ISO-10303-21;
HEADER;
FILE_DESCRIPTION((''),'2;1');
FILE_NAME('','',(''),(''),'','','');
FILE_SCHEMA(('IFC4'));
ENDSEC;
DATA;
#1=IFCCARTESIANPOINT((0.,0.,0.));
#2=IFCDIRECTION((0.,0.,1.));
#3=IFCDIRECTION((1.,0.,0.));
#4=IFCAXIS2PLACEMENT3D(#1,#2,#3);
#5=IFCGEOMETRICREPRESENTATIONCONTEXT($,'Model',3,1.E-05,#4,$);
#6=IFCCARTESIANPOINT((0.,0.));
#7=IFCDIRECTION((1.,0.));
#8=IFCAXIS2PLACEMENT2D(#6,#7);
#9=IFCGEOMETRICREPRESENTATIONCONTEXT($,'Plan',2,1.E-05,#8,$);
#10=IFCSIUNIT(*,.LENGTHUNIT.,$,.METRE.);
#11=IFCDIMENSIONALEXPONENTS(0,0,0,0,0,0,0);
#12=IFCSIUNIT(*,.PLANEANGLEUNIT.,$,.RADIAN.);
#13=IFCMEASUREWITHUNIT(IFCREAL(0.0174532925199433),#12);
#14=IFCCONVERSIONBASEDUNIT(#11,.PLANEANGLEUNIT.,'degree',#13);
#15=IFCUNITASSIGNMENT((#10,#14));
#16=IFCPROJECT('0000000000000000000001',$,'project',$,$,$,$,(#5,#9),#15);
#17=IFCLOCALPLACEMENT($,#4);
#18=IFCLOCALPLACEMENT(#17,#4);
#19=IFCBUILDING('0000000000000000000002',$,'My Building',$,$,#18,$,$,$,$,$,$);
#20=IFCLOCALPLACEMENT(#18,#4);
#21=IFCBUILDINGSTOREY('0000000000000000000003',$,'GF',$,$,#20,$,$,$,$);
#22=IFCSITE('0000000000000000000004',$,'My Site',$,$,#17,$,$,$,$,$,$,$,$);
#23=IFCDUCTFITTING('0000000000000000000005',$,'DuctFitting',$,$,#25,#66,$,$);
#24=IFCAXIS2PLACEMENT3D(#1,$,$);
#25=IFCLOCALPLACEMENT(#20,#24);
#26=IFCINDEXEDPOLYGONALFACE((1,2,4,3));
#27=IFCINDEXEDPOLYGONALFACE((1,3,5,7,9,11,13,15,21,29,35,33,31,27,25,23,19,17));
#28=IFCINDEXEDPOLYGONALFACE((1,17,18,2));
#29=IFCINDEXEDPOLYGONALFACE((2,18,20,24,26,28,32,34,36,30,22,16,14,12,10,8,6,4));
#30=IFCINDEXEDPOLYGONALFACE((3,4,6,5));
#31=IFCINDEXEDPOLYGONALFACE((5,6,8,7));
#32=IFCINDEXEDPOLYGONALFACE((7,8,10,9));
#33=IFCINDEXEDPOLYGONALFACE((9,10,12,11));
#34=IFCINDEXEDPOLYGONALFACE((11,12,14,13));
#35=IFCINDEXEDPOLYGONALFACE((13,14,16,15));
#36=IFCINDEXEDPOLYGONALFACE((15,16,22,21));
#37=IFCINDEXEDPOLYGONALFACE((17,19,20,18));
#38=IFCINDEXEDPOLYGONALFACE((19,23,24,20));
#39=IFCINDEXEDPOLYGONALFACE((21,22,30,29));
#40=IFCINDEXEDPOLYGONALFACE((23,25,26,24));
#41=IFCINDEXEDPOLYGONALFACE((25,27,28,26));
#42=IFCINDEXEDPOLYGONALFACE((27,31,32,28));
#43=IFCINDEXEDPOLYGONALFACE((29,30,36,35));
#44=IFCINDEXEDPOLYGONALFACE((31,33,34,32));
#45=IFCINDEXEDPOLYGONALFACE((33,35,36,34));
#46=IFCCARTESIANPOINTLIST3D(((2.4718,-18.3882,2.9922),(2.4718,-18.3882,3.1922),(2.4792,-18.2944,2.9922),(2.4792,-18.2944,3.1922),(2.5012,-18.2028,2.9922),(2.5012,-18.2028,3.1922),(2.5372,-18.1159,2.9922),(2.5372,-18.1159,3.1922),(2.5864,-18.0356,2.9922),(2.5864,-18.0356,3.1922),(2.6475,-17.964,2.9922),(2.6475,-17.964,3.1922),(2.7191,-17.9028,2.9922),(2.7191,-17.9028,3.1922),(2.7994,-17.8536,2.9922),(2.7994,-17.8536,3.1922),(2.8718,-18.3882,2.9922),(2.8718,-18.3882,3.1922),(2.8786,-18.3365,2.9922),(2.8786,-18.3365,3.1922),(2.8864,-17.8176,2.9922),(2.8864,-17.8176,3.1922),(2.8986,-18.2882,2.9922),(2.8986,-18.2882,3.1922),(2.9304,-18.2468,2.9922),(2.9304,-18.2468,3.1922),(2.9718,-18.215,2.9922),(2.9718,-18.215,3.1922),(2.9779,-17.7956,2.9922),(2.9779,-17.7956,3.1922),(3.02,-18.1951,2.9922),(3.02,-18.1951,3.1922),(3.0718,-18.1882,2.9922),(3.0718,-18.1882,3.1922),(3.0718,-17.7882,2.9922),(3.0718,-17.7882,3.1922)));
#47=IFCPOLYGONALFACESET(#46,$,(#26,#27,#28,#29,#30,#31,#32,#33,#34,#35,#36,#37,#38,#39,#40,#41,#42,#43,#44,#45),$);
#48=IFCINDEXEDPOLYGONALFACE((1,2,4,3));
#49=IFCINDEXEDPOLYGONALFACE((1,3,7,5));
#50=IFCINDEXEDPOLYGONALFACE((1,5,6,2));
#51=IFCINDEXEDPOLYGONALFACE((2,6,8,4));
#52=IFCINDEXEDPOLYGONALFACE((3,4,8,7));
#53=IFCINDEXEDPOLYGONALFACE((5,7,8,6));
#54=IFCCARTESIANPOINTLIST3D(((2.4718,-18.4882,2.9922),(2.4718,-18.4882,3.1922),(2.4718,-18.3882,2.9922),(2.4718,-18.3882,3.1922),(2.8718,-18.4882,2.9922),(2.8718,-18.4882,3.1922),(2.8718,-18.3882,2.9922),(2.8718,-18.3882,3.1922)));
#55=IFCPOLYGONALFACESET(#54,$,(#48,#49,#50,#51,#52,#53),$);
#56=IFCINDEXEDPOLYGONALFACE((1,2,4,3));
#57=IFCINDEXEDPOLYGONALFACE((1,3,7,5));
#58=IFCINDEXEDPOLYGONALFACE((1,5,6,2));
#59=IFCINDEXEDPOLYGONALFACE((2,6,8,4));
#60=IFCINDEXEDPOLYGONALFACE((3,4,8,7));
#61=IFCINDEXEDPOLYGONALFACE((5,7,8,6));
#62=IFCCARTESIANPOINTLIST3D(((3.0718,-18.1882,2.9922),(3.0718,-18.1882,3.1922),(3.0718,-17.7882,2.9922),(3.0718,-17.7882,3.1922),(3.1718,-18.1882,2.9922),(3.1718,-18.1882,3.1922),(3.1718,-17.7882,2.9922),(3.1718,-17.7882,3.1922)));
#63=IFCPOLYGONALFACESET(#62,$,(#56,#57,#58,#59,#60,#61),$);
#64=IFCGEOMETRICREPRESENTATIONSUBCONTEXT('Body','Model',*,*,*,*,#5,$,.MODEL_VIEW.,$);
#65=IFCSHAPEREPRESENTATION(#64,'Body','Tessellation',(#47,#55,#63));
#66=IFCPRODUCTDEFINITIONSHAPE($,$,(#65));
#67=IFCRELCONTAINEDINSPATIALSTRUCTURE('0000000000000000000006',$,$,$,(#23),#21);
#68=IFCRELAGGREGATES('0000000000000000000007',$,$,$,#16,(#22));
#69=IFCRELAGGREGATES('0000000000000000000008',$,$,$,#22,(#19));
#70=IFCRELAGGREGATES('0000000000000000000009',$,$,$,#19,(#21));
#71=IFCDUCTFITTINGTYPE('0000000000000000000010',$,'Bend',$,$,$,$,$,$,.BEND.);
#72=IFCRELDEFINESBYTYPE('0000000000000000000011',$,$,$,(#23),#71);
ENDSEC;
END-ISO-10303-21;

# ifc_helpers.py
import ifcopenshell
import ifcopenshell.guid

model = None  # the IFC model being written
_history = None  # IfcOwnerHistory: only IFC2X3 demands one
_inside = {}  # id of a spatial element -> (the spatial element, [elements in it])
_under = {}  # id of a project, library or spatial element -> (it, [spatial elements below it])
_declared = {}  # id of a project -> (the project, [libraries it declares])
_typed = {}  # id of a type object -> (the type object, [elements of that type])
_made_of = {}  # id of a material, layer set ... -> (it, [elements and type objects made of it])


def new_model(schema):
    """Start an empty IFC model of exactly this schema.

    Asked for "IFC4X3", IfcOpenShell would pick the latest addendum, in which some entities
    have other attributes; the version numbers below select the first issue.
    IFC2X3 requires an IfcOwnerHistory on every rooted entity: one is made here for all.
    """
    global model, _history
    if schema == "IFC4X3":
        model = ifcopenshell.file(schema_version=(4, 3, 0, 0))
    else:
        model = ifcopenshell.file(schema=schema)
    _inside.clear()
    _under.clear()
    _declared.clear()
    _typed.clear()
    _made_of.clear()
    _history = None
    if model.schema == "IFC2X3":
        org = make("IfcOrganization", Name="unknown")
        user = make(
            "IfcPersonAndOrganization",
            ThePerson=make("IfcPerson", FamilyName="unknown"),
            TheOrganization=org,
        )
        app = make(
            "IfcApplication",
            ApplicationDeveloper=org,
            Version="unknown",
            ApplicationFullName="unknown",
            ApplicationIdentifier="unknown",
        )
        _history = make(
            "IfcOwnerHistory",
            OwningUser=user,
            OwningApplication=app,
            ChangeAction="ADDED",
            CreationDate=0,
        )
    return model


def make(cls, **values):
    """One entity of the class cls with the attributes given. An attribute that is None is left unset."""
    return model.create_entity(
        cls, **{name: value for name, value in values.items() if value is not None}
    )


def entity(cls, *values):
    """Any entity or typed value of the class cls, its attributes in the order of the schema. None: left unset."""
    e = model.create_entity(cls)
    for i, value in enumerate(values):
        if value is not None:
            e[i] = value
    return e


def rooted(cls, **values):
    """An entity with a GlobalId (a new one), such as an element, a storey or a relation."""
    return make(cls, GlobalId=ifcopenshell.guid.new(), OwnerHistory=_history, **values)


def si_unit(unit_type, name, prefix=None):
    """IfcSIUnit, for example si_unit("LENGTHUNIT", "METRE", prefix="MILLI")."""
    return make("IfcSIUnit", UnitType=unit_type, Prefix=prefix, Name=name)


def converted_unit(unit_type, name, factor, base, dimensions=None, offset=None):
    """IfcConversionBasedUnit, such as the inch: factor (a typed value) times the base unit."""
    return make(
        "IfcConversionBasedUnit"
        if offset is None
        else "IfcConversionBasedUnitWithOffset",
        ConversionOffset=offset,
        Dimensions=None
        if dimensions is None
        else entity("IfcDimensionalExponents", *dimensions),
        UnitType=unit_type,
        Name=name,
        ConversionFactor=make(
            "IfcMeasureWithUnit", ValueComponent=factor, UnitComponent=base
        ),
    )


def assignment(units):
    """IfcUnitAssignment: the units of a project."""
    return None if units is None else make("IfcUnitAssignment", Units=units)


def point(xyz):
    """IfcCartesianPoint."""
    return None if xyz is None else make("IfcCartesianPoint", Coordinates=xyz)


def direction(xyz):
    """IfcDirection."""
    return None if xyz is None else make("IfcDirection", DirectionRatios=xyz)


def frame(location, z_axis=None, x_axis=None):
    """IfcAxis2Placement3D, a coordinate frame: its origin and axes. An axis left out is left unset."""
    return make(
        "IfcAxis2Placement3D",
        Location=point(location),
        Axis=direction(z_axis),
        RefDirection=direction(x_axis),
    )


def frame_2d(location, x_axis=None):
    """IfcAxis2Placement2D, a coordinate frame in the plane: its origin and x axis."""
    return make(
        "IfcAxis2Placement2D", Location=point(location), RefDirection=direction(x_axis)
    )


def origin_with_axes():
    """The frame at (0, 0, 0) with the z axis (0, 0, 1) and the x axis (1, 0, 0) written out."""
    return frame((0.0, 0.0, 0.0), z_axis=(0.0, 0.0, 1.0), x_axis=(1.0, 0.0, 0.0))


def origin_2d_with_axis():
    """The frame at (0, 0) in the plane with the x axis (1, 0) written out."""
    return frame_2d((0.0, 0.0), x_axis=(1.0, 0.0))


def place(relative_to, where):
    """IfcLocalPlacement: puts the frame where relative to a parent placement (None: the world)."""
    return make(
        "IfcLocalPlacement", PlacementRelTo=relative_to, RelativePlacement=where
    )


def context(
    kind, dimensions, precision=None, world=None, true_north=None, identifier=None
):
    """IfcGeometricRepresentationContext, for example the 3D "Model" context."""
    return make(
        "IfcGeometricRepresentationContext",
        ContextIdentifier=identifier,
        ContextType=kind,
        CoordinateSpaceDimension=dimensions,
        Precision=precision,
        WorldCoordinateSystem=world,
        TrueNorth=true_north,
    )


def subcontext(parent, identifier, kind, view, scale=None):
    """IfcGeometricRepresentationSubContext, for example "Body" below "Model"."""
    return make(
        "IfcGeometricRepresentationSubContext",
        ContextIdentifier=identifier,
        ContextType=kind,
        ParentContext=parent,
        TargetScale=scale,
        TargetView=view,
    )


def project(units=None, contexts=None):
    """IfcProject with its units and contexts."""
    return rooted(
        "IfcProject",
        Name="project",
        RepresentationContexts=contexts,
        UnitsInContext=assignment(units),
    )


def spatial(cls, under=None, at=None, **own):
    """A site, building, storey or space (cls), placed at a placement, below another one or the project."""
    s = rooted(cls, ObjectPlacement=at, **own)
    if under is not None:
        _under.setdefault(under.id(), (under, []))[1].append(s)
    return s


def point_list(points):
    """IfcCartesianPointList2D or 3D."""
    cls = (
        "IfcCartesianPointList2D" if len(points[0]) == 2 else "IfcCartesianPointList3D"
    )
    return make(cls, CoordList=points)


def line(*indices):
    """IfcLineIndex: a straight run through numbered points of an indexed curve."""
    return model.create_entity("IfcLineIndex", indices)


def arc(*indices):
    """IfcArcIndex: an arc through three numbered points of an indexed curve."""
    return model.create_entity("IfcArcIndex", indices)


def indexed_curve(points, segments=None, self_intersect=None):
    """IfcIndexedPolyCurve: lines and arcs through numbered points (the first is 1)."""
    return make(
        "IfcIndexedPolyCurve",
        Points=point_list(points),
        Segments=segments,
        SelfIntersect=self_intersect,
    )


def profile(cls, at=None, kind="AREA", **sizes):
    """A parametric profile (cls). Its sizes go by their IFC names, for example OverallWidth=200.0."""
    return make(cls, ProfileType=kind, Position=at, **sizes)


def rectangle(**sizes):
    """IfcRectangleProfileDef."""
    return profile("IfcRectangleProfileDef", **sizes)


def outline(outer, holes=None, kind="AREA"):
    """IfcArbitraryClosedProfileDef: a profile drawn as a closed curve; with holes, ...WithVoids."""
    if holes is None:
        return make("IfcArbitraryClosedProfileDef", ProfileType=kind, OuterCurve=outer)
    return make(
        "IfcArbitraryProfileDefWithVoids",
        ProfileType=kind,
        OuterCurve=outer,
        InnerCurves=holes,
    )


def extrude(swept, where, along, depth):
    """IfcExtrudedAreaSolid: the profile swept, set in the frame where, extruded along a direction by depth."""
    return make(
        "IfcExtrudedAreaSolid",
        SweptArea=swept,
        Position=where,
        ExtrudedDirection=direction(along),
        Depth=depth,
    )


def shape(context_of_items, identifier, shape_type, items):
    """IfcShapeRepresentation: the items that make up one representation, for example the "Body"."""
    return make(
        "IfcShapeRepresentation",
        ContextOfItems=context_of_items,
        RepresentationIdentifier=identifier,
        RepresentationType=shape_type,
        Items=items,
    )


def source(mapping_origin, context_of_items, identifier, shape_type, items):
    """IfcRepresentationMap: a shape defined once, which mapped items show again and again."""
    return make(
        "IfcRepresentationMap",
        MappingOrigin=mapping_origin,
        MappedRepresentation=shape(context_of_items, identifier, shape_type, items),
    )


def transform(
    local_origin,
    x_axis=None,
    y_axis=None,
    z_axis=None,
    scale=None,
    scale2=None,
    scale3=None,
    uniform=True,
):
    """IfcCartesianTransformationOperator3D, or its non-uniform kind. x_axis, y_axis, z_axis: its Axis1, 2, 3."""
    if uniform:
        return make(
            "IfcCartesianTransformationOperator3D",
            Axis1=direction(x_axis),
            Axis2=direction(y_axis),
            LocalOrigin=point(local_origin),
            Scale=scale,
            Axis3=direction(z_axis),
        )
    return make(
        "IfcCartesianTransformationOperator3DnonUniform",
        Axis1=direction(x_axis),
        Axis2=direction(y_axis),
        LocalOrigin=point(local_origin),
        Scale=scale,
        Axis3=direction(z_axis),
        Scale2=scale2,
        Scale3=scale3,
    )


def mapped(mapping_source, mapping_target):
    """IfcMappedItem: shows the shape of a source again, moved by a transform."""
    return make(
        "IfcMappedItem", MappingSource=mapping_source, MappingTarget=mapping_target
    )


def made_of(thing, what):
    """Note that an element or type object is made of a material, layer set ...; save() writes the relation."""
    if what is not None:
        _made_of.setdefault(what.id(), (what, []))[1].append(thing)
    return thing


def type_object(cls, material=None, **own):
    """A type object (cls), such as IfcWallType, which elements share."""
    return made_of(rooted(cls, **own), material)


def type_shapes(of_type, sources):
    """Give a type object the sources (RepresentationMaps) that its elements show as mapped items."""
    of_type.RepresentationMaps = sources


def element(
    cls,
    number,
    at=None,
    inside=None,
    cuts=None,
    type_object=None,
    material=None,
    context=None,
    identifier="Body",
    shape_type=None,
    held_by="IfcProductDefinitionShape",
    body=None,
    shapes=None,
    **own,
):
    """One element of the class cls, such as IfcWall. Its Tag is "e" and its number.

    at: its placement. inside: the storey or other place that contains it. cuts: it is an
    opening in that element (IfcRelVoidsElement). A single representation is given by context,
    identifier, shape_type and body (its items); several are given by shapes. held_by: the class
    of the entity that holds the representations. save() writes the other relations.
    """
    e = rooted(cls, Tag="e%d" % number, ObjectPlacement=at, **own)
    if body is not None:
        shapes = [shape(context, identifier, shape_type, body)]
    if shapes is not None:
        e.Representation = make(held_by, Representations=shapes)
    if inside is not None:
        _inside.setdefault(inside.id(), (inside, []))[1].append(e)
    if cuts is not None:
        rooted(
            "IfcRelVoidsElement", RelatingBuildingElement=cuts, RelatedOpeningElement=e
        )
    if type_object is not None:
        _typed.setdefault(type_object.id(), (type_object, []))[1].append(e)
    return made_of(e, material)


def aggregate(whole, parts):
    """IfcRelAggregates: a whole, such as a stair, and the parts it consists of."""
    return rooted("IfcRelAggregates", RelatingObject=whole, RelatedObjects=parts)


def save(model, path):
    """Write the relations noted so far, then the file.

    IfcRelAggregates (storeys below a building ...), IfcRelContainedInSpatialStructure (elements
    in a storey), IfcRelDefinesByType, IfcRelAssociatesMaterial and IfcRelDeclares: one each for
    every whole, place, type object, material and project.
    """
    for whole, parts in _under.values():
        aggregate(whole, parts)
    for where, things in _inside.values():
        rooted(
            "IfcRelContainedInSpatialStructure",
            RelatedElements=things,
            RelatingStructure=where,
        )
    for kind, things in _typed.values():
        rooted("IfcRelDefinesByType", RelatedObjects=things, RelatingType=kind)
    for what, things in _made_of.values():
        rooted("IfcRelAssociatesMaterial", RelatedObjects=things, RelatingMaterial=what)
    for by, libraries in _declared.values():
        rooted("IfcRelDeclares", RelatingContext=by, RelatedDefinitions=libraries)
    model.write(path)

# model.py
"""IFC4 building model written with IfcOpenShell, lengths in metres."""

from ifc_helpers import new_model, entity, si_unit, converted_unit, frame, origin_with_axes, origin_2d_with_axis, place, context, subcontext, project, spatial, line, arc, indexed_curve, rectangle, outline, extrude, source, transform, mapped, type_object, type_shapes, element, save


model = new_model("IFC4")

# Units and contexts
model_context = context("Model", 3, precision=1e-05, world=origin_with_axes())
plan_context = context("Plan", 2, precision=1e-05, world=origin_2d_with_axis())
body_context_1 = subcontext(model_context, "Body", "Model", "MODEL_VIEW")
ifc_project = project(units=[si_unit("LENGTHUNIT", "METRE"), converted_unit("PLANEANGLEUNIT", "degree", entity("IfcReal", 0.0174532925199433), si_unit("PLANEANGLEUNIT", "RADIAN"), dimensions=[0, 0, 0, 0, 0, 0, 0])], contexts=[model_context, plan_context])

# Site, building, storey
site_placement = place(None, origin_with_axes())
site = spatial("IfcSite", under=ifc_project, at=site_placement, Name="My Site")
building_placement = place(site_placement, origin_with_axes())
building = spatial("IfcBuilding", under=site, at=building_placement, Name="My Building")
storey_placement = place(building_placement, origin_with_axes())
storey = spatial("IfcBuildingStorey", under=building, at=storey_placement, Name="GF")

# Duct fitting
duct_fitting_type = type_object("IfcDuctFittingType", Name="Bend", PredefinedType="BEND")
shared_shape_1 = source(origin_with_axes(), body_context_1, "Body", "SweptSolid", [
    extrude(outline(indexed_curve([(0.2, 0.0), (0.2586, -0.1414), (0.4, -0.2), (0.4, -0.6), (-0.0243, -0.4243), (-0.2, 0.0)], segments=[arc(1, 2, 3), line(3, 4), arc(4, 5, 6), line(6, 1)])), frame((0.0, -0.1, -0.1), z_axis=(0.0, -1.0, 0.0), x_axis=(1.0, 0.0, 0.0)), (0.0, 0.0, -1.0), 0.2),
    extrude(rectangle(XDim=0.4, YDim=0.2), origin_with_axes(), (0.0, 0.0, -1.0), 0.1),
    extrude(rectangle(XDim=0.4, YDim=0.2), frame((0.4, 0.0, -0.5), z_axis=(1.0, 0.0, 0.0), x_axis=(0.0, 0.0, 1.0)), (0.0, 0.0, 1.0), 0.1),
])
type_shapes(duct_fitting_type, [shared_shape_1])
for number, where, z_axis, x_axis, name in (
    (1, (2.6718, -18.4882, 3.0922), (0.0, -1.0, 0.0), (1.0, 0.0, 0.0), "DuctFitting"),
):
    element("IfcDuctFitting", number, at=place(storey_placement, frame(where, z_axis=z_axis, x_axis=x_axis)), inside=storey, type_object=duct_fitting_type, Name=name, context=body_context_1, shape_type="MappedRepresentation", body=[
        mapped(shared_shape_1, transform((0.0, 0.0, 0.0), x_axis=(1.0, 0.0, 0.0), y_axis=(0.0, 1.0, 0.0), z_axis=(0.0, 0.0, 1.0), scale=1.0)),
    ])

save(model, "model.ifc")
